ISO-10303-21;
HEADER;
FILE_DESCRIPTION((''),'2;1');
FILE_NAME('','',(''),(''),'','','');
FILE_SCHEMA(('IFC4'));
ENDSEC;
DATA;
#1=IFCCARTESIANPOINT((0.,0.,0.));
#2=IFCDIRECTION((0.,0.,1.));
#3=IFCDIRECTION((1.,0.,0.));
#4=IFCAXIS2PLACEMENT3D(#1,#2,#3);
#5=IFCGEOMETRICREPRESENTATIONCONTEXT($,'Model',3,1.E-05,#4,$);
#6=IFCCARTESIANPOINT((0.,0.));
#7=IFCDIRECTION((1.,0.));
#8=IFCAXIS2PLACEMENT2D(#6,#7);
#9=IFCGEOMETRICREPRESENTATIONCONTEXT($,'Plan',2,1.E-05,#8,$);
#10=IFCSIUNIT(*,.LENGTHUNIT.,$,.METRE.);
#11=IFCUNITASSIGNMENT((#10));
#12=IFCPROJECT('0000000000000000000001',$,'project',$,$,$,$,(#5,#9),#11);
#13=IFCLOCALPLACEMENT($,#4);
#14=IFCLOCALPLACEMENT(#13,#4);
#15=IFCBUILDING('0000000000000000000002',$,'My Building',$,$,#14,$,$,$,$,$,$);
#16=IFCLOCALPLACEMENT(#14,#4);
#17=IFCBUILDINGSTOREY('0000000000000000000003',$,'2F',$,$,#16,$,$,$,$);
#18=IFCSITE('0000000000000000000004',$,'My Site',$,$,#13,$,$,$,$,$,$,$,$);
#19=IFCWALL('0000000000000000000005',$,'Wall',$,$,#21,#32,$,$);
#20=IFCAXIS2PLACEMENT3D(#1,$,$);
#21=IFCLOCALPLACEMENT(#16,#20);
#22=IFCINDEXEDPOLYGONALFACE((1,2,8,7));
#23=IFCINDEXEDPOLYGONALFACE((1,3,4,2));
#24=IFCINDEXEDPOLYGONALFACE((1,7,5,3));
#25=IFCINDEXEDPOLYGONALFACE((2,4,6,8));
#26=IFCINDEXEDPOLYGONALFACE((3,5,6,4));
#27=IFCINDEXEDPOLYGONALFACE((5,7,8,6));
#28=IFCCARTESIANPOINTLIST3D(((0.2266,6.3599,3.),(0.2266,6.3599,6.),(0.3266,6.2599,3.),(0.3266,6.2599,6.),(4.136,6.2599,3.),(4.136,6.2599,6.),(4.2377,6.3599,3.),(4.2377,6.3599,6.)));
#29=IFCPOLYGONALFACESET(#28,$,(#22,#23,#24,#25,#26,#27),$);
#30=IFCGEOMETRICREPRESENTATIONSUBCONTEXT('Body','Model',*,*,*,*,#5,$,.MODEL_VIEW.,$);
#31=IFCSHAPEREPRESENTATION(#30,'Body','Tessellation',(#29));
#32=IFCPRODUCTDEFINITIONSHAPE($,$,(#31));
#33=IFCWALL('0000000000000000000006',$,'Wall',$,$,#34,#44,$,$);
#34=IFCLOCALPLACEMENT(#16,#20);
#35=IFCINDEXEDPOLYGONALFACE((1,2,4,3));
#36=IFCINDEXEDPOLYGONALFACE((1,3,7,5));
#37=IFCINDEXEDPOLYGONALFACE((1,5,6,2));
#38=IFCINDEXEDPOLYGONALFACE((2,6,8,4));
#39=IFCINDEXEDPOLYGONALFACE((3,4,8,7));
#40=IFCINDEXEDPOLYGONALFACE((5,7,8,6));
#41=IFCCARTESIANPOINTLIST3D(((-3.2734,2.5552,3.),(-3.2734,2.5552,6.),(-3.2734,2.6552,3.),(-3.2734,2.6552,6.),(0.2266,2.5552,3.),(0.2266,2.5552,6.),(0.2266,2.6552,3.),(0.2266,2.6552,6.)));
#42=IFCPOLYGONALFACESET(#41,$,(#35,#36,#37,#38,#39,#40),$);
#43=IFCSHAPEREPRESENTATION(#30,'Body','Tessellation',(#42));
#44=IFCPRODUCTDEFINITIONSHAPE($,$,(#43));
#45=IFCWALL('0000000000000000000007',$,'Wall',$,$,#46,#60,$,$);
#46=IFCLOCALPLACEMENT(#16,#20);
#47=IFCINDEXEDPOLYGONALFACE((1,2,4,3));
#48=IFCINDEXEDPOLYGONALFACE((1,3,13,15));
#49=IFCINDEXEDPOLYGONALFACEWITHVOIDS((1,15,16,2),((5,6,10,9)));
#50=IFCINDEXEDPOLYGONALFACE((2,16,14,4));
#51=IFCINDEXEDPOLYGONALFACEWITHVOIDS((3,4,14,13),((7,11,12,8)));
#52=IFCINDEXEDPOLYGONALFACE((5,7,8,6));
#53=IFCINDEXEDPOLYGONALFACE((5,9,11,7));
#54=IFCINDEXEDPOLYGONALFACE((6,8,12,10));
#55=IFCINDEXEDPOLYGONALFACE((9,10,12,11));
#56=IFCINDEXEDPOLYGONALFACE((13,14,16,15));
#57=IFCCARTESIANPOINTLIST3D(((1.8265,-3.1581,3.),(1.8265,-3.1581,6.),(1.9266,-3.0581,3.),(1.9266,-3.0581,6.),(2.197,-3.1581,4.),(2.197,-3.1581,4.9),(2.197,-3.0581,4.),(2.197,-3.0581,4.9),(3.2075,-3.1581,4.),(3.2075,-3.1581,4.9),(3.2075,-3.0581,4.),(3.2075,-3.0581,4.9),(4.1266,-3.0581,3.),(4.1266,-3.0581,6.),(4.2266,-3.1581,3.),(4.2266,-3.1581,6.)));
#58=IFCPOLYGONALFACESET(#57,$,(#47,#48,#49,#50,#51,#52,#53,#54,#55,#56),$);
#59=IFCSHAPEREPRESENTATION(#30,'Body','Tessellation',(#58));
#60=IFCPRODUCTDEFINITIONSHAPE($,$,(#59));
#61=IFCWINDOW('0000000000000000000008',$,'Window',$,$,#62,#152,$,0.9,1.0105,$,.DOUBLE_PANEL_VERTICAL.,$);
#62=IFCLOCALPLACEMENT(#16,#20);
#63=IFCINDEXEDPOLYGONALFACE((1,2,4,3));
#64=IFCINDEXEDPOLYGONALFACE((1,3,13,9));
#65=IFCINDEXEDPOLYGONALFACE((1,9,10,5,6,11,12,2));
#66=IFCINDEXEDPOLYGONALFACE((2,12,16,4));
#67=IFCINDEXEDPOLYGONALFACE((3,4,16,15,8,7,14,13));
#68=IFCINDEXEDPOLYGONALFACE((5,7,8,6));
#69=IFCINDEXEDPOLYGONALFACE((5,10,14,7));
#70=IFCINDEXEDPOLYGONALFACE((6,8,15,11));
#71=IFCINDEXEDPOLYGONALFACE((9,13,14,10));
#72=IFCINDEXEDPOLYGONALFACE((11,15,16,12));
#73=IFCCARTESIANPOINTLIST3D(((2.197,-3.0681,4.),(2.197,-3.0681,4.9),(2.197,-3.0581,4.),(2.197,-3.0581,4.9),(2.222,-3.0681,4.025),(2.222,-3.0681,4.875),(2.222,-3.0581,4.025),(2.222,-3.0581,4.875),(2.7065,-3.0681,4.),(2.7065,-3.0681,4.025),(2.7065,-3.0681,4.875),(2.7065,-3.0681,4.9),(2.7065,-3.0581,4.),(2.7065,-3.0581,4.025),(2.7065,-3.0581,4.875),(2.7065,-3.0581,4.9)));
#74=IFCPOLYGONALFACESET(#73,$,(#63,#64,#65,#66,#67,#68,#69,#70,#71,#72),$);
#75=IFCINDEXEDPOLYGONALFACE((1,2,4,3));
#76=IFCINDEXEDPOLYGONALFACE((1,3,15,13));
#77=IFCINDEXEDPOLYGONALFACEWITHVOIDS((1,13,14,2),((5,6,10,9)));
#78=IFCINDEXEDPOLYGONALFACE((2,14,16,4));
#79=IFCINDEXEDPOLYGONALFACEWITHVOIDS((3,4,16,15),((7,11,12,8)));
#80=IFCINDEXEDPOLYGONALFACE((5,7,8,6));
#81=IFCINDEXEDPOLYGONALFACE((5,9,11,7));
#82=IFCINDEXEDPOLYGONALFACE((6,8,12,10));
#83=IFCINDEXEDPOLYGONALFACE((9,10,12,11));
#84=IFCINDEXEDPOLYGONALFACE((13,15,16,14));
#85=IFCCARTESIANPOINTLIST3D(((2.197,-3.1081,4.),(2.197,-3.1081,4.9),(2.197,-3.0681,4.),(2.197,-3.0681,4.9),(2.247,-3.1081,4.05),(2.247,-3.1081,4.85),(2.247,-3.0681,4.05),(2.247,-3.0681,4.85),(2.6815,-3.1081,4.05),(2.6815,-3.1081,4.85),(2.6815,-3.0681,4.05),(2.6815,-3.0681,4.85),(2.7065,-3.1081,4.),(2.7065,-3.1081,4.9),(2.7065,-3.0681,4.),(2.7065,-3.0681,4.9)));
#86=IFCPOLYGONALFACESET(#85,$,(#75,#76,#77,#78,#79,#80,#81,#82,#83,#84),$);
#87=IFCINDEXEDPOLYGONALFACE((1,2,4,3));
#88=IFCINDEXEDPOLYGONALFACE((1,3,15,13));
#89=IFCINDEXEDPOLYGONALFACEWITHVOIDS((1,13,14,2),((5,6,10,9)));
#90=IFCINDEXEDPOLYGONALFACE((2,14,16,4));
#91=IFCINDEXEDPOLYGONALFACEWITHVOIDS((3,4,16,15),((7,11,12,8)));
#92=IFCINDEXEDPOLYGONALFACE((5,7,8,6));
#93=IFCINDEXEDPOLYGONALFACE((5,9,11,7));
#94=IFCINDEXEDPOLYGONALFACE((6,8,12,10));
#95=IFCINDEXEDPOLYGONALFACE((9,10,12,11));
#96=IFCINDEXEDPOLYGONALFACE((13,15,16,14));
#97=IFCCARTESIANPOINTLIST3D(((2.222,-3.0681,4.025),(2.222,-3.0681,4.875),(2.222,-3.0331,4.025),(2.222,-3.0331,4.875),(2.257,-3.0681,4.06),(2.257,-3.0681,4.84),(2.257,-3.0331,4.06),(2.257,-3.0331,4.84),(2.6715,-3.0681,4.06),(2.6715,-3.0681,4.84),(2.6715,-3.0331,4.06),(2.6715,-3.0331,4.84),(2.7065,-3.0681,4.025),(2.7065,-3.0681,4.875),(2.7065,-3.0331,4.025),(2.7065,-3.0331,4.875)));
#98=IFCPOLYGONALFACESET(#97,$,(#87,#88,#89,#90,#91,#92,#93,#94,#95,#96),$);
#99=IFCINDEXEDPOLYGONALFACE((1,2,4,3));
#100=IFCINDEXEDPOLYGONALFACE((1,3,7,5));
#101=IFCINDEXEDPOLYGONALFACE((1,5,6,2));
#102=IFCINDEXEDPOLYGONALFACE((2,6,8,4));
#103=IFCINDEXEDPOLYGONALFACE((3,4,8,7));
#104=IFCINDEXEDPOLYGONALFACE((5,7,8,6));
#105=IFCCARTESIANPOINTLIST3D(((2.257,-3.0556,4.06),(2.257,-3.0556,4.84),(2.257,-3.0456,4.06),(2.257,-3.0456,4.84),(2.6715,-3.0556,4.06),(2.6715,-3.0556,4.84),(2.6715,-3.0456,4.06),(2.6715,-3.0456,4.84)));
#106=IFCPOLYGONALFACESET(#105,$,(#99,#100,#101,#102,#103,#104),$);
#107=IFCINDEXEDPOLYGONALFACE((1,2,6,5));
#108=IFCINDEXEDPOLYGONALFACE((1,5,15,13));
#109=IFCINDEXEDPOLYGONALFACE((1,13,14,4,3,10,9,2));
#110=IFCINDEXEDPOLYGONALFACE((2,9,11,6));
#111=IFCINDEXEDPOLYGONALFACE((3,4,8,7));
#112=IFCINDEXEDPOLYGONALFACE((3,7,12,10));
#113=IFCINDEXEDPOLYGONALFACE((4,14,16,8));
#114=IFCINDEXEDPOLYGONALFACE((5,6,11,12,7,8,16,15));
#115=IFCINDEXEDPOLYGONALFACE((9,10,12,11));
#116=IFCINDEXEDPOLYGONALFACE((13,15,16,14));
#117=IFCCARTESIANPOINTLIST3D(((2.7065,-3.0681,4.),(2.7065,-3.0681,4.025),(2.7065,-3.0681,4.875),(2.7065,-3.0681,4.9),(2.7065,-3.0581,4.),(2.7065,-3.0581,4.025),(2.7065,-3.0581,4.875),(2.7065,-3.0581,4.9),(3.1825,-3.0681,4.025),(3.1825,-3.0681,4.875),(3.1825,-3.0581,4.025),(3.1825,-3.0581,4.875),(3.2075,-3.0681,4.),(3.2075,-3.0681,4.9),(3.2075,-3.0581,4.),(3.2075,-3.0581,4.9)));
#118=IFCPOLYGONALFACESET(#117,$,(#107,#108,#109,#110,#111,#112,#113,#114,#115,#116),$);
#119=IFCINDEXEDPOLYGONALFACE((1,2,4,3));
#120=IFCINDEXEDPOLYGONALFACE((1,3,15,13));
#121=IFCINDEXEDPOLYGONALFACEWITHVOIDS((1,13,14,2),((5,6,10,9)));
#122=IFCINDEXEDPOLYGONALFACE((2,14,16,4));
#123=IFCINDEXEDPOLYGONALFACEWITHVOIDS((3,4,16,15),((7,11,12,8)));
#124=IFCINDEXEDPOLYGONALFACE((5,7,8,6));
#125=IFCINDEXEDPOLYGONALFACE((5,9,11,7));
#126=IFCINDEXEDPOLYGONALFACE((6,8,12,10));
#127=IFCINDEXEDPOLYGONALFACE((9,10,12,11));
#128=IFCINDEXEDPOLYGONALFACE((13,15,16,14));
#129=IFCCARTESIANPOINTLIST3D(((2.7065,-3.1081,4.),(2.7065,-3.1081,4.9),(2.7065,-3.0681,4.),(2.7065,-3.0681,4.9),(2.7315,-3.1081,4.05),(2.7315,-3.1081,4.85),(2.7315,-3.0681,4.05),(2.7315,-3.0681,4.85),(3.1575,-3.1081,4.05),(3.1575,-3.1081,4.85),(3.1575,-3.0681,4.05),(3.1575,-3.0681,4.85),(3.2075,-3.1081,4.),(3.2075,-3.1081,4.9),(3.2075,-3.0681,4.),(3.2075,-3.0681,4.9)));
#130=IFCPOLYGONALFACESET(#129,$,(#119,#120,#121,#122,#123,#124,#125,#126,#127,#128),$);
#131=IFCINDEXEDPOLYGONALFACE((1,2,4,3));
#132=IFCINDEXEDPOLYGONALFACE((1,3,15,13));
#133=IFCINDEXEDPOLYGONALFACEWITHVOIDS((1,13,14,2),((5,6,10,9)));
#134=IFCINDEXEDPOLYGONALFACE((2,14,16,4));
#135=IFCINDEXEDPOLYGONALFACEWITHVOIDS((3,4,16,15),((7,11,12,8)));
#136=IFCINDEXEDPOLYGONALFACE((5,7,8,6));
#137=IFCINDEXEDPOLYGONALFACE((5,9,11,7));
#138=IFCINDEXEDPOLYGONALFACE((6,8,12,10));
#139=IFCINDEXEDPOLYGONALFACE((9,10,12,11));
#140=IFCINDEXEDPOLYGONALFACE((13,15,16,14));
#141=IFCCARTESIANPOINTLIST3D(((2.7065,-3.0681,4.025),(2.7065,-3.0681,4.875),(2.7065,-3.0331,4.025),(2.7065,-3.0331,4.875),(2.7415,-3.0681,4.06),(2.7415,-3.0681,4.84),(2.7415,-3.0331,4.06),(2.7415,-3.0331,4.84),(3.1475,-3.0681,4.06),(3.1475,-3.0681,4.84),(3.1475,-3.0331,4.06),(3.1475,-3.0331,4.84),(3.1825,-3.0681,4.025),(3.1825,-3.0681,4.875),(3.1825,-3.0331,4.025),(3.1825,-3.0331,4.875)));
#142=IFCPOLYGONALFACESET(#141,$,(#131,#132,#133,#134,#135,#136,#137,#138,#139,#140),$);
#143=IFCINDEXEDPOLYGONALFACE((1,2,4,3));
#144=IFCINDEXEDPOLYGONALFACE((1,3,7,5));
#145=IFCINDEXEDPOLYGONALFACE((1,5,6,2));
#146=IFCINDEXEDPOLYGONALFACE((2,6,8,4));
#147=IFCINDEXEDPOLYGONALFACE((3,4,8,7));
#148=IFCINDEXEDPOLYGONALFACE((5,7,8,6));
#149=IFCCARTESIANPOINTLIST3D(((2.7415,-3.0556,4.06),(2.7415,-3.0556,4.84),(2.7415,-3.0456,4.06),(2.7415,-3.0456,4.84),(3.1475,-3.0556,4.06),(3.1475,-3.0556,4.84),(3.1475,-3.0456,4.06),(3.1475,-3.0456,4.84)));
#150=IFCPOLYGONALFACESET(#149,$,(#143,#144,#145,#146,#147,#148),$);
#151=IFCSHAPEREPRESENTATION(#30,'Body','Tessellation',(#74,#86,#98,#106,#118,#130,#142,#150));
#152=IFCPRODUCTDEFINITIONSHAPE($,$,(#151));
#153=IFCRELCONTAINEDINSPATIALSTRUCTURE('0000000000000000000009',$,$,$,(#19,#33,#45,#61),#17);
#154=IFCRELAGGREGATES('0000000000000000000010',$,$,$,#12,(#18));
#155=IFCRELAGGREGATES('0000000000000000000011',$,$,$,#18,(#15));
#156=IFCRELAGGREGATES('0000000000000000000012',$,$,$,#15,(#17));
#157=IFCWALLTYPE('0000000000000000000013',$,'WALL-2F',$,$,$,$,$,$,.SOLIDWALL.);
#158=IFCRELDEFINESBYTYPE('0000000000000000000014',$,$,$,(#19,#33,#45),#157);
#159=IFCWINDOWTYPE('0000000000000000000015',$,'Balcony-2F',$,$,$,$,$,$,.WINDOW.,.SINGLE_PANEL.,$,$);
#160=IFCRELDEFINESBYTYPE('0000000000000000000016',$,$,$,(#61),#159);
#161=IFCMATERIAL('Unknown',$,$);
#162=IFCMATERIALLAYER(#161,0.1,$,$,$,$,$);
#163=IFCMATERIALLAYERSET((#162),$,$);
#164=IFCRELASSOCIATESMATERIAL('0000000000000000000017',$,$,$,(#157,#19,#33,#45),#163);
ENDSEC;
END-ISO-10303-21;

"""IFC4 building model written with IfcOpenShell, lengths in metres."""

from ifc_helpers import new_model, entity, si_unit, frame, origin_with_axes, origin_2d_with_axis, place, context, subcontext, project, spatial, line, indexed_curve, outline, extrude, shape, source, transform, mapped, material, layer, layer_set, layer_usage, type_object, type_shapes, element, fill, save


model = new_model("IFC4")

# Units and contexts
model_context = context("Model", 3, precision=1e-05, world=origin_with_axes())
plan_context = context("Plan", 2, precision=1e-05, world=origin_2d_with_axis())
body_context_1 = subcontext(model_context, "Body", "Model", "MODEL_VIEW")
body_context_2 = subcontext(plan_context, "Body", "Plan", "PLAN_VIEW")
ifc_project = project(units=[si_unit("LENGTHUNIT", "METRE")], contexts=[model_context, plan_context])

# Site, building, storey
site_placement = place(None, origin_with_axes())
site = spatial("IfcSite", under=ifc_project, at=site_placement, Name="My Site")
building_placement = place(site_placement, origin_with_axes())
building = spatial("IfcBuilding", under=site, at=building_placement, Name="My Building")
storey_placement = place(building_placement, origin_with_axes())
storey = spatial("IfcBuildingStorey", under=building, at=storey_placement, Name="2F")

# Wall
ifc_material = material(Name="Unknown")
ifc_layer_1 = layer(ifc_material, 0.1)
ifc_layer_set_1 = layer_set([ifc_layer_1])
ifc_layer_usage_1 = layer_usage(ifc_layer_set_1, "AXIS2", "POSITIVE", 0.0)
wall_type_1 = type_object("IfcWallType", Name="WALL-2F", PredefinedType="SOLIDWALL", material=ifc_layer_set_1)
wall_1_placement = place(storey_placement, frame((4.2377, 6.3599, 3.0), z_axis=(0.0, 0.0, 1.0), x_axis=(-1.0, 0.0, 0.0)))
element("IfcWall", 1, at=wall_1_placement, inside=storey, type_object=wall_type_1, material=ifc_layer_usage_1, Name="Wall", context=body_context_1, shape_type="SweptSolid", body=[
    extrude(outline(indexed_curve([(0.0, 0.0), (0.1017, 0.1), (3.9111, 0.1), (4.0111, 0.0)], segments=[line(1, 2, 3, 4, 1)])), origin_with_axes(), (0.0, 0.0, 1.0), 3.0),
])

# Wall
ifc_layer_usage_2 = layer_usage(ifc_layer_set_1, "AXIS2", "POSITIVE", 0.0)
wall_2_placement = place(storey_placement, frame((-3.2734, 2.5552, 3.0), z_axis=(0.0, 0.0, 1.0), x_axis=(1.0, 0.0, 0.0)))
element("IfcWall", 2, at=wall_2_placement, inside=storey, type_object=wall_type_1, material=ifc_layer_usage_2, Name="Wall", context=body_context_1, shape_type="SweptSolid", body=[
    extrude(outline(indexed_curve([(0.0, 0.0), (0.0, 0.1), (3.5, 0.1), (3.5, 0.0)], segments=[line(1, 2, 3, 4, 1)])), origin_with_axes(), (0.0, 0.0, 1.0), 3.0),
])

# Wall, opening, window
ifc_layer_usage_3 = layer_usage(ifc_layer_set_1, "AXIS2", "POSITIVE", 0.0)
wall_3_placement = place(storey_placement, frame((4.1266, -3.0581, 3.0), z_axis=(0.0, 0.0, 1.0), x_axis=(-1.0, 0.0, 0.0)))
wall_3 = element("IfcWall", 3, at=wall_3_placement, inside=storey, type_object=wall_type_1, material=ifc_layer_usage_3, Name="Wall", context=body_context_1, shape_type="SweptSolid", body=[
    extrude(outline(indexed_curve([(0.0, 0.0), (-0.1, 0.1), (2.3001, 0.1), (2.2, 0.0)], segments=[line(1, 2, 3, 4, 1)])), origin_with_axes(), (0.0, 0.0, 1.0), 3.0),
])
shared_shape_1 = source(origin_with_axes(), body_context_1, "Body", "SweptSolid", [
    extrude(outline(indexed_curve([(0.0, 0.0), (1.0105, 0.0), (1.0105, 0.9), (0.0, 0.9)], segments=[line(1, 2, 3, 4, 1)])), frame((0.0, -0.6, 0.0), z_axis=(0.0, -1.0, 0.0), x_axis=(1.0, 0.0, 0.0)), (0.0, 0.0, -1.0), 1.2),
])
opening_1_placement = place(wall_3_placement, frame((1.9296, 0.1, 1.0), z_axis=(0.0, 0.0, 1.0), x_axis=(-1.0, 0.0, 0.0)))
opening_1 = element("IfcOpeningElement", 4, at=opening_1_placement, cuts=wall_3, PredefinedType="OPENING", context=body_context_1, shape_type="MappedRepresentation", body=[
    mapped(shared_shape_1, transform((0.0, 0.0, 0.0), x_axis=(1.0, 0.0, 0.0), y_axis=(0.0, 1.0, 0.0), z_axis=(0.0, 0.0, 1.0), scale=1.0)),
])
window_type_1 = type_object("IfcWindowType", Name="Balcony-2F", PartitioningType="SINGLE_PANEL", PredefinedType="WINDOW")
shared_shape_2 = source(origin_with_axes(), body_context_1, "Body", "SweptSolid", [
    extrude(outline(indexed_curve([(0.5096, 0.0), (0.0, 0.0), (0.0, 0.9), (0.5096, 0.9), (0.5096, 0.875), (0.025, 0.875), (0.025, 0.025), (0.5096, 0.025)], segments=[line(1, 2, 3, 4, 5, 6, 7, 8, 1)])), frame((0.0, 0.09, 0.0), z_axis=(0.0, -1.0, 0.0), x_axis=(1.0, 0.0, 0.0)), (0.0, 0.0, -1.0), 0.01),
    extrude(outline(indexed_curve([(0.0, 0.0), (0.5096, 0.0), (0.5096, 0.9), (0.0, 0.9)], segments=[line(1, 2, 3, 4, 1)]), holes=[indexed_curve([(0.05, 0.05), (0.4846, 0.05), (0.4846, 0.85), (0.05, 0.85)], segments=[line(1, 2, 3, 4, 1)])]), frame((0.0, 0.05, 0.0), z_axis=(0.0, -1.0, 0.0), x_axis=(1.0, 0.0, 0.0)), (0.0, 0.0, -1.0), 0.04),
    extrude(outline(indexed_curve([(0.0, 0.0), (0.4846, 0.0), (0.4846, 0.85), (0.0, 0.85)], segments=[line(1, 2, 3, 4, 1)]), holes=[indexed_curve([(0.035, 0.035), (0.4496, 0.035), (0.4496, 0.815), (0.035, 0.815)], segments=[line(1, 2, 3, 4, 1)])]), frame((0.025, 0.09, 0.025), z_axis=(0.0, -1.0, 0.0), x_axis=(1.0, 0.0, 0.0)), (0.0, 0.0, -1.0), 0.035),
    extrude(outline(indexed_curve([(0.035, 0.035), (0.4496, 0.035), (0.4496, 0.815), (0.035, 0.815)], segments=[line(1, 2, 3, 4, 1)])), frame((0.025, 0.1025, 0.025), z_axis=(0.0, -1.0, 0.0), x_axis=(1.0, 0.0, 0.0)), (0.0, 0.0, -1.0), 0.01),
    extrude(outline(indexed_curve([(0.0, 0.9), (0.501, 0.9), (0.501, 0.0), (0.0, 0.0), (0.0, 0.025), (0.476, 0.025), (0.476, 0.875), (0.0, 0.875)], segments=[line(1, 2, 3, 4, 5, 6, 7, 8, 1)])), frame((0.5096, 0.09, 0.0), z_axis=(0.0, -1.0, 0.0), x_axis=(1.0, 0.0, 0.0)), (0.0, 0.0, -1.0), 0.01),
    extrude(outline(indexed_curve([(0.0, 0.0), (0.501, 0.0), (0.501, 0.9), (0.0, 0.9)], segments=[line(1, 2, 3, 4, 1)]), holes=[indexed_curve([(0.025, 0.05), (0.451, 0.05), (0.451, 0.85), (0.025, 0.85)], segments=[line(1, 2, 3, 4, 1)])]), frame((0.5096, 0.05, 0.0), z_axis=(0.0, -1.0, 0.0), x_axis=(1.0, 0.0, 0.0)), (0.0, 0.0, -1.0), 0.04),
    extrude(outline(indexed_curve([(0.0, 0.0), (0.476, 0.0), (0.476, 0.85), (0.0, 0.85)], segments=[line(1, 2, 3, 4, 1)]), holes=[indexed_curve([(0.035, 0.035), (0.441, 0.035), (0.441, 0.815), (0.035, 0.815)], segments=[line(1, 2, 3, 4, 1)])]), frame((0.5096, 0.09, 0.025), z_axis=(0.0, -1.0, 0.0), x_axis=(1.0, 0.0, 0.0)), (0.0, 0.0, -1.0), 0.035),
    extrude(outline(indexed_curve([(0.035, 0.035), (0.441, 0.035), (0.441, 0.815), (0.035, 0.815)], segments=[line(1, 2, 3, 4, 1)])), frame((0.5096, 0.1025, 0.025), z_axis=(0.0, -1.0, 0.0), x_axis=(1.0, 0.0, 0.0)), (0.0, 0.0, -1.0), 0.01),
])
shared_shape_3 = source(origin_with_axes(), body_context_2, "Body", "Curve2D", [
    entity("IfcIndexedPolyCurve", entity("IfcCartesianPointList2D", [[0.05, 0.05], [0.4846, 0.05]])),
    entity("IfcIndexedPolyCurve", entity("IfcCartesianPointList2D", [[0.0, 0.1], [0.025, 0.1], [0.025, 0.09], [0.05, 0.09], [0.05, 0.05], [0.0, 0.05]]), [entity("IfcLineIndex", [1, 2, 3, 4, 5, 6, 1])]),
    entity("IfcIndexedPolyCurve", entity("IfcCartesianPointList2D", [[0.5096, 0.1], [0.5096, 0.1], [0.5096, 0.09], [0.4846, 0.09], [0.4846, 0.05], [0.5096, 0.05]])),
    entity("IfcIndexedPolyCurve", entity("IfcCartesianPointList2D", [[0.025, 0.09], [0.06, 0.09], [0.06, 0.125], [0.025, 0.125]]), [entity("IfcLineIndex", [1, 2, 3, 4, 1])]),
    entity("IfcIndexedPolyCurve", entity("IfcCartesianPointList2D", [[0.5096, 0.09], [0.4746, 0.09], [0.4746, 0.125], [0.5096, 0.125]]), [entity("IfcLineIndex", [1, 2, 3, 4, 1])]),
    entity("IfcIndexedPolyCurve", entity("IfcCartesianPointList2D", [[0.06, 0.09], [0.4746, 0.09]])),
    entity("IfcIndexedPolyCurve", entity("IfcCartesianPointList2D", [[0.06, 0.125], [0.4746, 0.125]])),
    entity("IfcIndexedPolyCurve", entity("IfcCartesianPointList2D", [[0.06, 0.1075], [0.4746, 0.1075]])),
    entity("IfcIndexedPolyCurve", entity("IfcCartesianPointList2D", [[0.5346, 0.05], [0.9605, 0.05]])),
    entity("IfcIndexedPolyCurve", entity("IfcCartesianPointList2D", [[0.5096, 0.1], [0.5096, 0.1], [0.5096, 0.09], [0.5346, 0.09], [0.5346, 0.05], [0.5096, 0.05]])),
    entity("IfcIndexedPolyCurve", entity("IfcCartesianPointList2D", [[1.0105, 0.1], [0.9855, 0.1], [0.9855, 0.09], [0.9605, 0.09], [0.9605, 0.05], [1.0105, 0.05]]), [entity("IfcLineIndex", [1, 2, 3, 4, 5, 6, 1])]),
    entity("IfcIndexedPolyCurve", entity("IfcCartesianPointList2D", [[0.5096, 0.09], [0.5446, 0.09], [0.5446, 0.125], [0.5096, 0.125]]), [entity("IfcLineIndex", [1, 2, 3, 4, 1])]),
    entity("IfcIndexedPolyCurve", entity("IfcCartesianPointList2D", [[0.9855, 0.09], [0.9505, 0.09], [0.9505, 0.125], [0.9855, 0.125]]), [entity("IfcLineIndex", [1, 2, 3, 4, 1])]),
    entity("IfcIndexedPolyCurve", entity("IfcCartesianPointList2D", [[0.5446, 0.09], [0.9505, 0.09]])),
    entity("IfcIndexedPolyCurve", entity("IfcCartesianPointList2D", [[0.5446, 0.125], [0.9505, 0.125]])),
    entity("IfcIndexedPolyCurve", entity("IfcCartesianPointList2D", [[0.5446, 0.1075], [0.9505, 0.1075]])),
])
type_shapes(window_type_1, [shared_shape_2, shared_shape_3])
window_1_placement = place(opening_1_placement, frame((0.0, 0.0, 0.0), z_axis=(0.0, 0.0, 1.0), x_axis=(1.0, 0.0, 0.0)))
window_1 = element("IfcWindow", 5, at=window_1_placement, inside=storey, type_object=window_type_1, Name="Window", OverallHeight=0.9, OverallWidth=1.0105, PartitioningType="DOUBLE_PANEL_VERTICAL", shapes=[
    shape(body_context_1, "Body", "MappedRepresentation", [mapped(shared_shape_2, transform((0.0, 0.0, 0.0), x_axis=(1.0, 0.0, 0.0), y_axis=(0.0, 1.0, 0.0), z_axis=(0.0, 0.0, 1.0), scale=1.0))]),
    shape(body_context_2, "Body", "MappedRepresentation", [mapped(shared_shape_3, transform((0.0, 0.0, 0.0), x_axis=(1.0, 0.0, 0.0), y_axis=(0.0, 1.0, 0.0), z_axis=(0.0, 0.0, 1.0), scale=1.0))]),
])
fill(opening_1, window_1)

save(model, "model.ifc")
